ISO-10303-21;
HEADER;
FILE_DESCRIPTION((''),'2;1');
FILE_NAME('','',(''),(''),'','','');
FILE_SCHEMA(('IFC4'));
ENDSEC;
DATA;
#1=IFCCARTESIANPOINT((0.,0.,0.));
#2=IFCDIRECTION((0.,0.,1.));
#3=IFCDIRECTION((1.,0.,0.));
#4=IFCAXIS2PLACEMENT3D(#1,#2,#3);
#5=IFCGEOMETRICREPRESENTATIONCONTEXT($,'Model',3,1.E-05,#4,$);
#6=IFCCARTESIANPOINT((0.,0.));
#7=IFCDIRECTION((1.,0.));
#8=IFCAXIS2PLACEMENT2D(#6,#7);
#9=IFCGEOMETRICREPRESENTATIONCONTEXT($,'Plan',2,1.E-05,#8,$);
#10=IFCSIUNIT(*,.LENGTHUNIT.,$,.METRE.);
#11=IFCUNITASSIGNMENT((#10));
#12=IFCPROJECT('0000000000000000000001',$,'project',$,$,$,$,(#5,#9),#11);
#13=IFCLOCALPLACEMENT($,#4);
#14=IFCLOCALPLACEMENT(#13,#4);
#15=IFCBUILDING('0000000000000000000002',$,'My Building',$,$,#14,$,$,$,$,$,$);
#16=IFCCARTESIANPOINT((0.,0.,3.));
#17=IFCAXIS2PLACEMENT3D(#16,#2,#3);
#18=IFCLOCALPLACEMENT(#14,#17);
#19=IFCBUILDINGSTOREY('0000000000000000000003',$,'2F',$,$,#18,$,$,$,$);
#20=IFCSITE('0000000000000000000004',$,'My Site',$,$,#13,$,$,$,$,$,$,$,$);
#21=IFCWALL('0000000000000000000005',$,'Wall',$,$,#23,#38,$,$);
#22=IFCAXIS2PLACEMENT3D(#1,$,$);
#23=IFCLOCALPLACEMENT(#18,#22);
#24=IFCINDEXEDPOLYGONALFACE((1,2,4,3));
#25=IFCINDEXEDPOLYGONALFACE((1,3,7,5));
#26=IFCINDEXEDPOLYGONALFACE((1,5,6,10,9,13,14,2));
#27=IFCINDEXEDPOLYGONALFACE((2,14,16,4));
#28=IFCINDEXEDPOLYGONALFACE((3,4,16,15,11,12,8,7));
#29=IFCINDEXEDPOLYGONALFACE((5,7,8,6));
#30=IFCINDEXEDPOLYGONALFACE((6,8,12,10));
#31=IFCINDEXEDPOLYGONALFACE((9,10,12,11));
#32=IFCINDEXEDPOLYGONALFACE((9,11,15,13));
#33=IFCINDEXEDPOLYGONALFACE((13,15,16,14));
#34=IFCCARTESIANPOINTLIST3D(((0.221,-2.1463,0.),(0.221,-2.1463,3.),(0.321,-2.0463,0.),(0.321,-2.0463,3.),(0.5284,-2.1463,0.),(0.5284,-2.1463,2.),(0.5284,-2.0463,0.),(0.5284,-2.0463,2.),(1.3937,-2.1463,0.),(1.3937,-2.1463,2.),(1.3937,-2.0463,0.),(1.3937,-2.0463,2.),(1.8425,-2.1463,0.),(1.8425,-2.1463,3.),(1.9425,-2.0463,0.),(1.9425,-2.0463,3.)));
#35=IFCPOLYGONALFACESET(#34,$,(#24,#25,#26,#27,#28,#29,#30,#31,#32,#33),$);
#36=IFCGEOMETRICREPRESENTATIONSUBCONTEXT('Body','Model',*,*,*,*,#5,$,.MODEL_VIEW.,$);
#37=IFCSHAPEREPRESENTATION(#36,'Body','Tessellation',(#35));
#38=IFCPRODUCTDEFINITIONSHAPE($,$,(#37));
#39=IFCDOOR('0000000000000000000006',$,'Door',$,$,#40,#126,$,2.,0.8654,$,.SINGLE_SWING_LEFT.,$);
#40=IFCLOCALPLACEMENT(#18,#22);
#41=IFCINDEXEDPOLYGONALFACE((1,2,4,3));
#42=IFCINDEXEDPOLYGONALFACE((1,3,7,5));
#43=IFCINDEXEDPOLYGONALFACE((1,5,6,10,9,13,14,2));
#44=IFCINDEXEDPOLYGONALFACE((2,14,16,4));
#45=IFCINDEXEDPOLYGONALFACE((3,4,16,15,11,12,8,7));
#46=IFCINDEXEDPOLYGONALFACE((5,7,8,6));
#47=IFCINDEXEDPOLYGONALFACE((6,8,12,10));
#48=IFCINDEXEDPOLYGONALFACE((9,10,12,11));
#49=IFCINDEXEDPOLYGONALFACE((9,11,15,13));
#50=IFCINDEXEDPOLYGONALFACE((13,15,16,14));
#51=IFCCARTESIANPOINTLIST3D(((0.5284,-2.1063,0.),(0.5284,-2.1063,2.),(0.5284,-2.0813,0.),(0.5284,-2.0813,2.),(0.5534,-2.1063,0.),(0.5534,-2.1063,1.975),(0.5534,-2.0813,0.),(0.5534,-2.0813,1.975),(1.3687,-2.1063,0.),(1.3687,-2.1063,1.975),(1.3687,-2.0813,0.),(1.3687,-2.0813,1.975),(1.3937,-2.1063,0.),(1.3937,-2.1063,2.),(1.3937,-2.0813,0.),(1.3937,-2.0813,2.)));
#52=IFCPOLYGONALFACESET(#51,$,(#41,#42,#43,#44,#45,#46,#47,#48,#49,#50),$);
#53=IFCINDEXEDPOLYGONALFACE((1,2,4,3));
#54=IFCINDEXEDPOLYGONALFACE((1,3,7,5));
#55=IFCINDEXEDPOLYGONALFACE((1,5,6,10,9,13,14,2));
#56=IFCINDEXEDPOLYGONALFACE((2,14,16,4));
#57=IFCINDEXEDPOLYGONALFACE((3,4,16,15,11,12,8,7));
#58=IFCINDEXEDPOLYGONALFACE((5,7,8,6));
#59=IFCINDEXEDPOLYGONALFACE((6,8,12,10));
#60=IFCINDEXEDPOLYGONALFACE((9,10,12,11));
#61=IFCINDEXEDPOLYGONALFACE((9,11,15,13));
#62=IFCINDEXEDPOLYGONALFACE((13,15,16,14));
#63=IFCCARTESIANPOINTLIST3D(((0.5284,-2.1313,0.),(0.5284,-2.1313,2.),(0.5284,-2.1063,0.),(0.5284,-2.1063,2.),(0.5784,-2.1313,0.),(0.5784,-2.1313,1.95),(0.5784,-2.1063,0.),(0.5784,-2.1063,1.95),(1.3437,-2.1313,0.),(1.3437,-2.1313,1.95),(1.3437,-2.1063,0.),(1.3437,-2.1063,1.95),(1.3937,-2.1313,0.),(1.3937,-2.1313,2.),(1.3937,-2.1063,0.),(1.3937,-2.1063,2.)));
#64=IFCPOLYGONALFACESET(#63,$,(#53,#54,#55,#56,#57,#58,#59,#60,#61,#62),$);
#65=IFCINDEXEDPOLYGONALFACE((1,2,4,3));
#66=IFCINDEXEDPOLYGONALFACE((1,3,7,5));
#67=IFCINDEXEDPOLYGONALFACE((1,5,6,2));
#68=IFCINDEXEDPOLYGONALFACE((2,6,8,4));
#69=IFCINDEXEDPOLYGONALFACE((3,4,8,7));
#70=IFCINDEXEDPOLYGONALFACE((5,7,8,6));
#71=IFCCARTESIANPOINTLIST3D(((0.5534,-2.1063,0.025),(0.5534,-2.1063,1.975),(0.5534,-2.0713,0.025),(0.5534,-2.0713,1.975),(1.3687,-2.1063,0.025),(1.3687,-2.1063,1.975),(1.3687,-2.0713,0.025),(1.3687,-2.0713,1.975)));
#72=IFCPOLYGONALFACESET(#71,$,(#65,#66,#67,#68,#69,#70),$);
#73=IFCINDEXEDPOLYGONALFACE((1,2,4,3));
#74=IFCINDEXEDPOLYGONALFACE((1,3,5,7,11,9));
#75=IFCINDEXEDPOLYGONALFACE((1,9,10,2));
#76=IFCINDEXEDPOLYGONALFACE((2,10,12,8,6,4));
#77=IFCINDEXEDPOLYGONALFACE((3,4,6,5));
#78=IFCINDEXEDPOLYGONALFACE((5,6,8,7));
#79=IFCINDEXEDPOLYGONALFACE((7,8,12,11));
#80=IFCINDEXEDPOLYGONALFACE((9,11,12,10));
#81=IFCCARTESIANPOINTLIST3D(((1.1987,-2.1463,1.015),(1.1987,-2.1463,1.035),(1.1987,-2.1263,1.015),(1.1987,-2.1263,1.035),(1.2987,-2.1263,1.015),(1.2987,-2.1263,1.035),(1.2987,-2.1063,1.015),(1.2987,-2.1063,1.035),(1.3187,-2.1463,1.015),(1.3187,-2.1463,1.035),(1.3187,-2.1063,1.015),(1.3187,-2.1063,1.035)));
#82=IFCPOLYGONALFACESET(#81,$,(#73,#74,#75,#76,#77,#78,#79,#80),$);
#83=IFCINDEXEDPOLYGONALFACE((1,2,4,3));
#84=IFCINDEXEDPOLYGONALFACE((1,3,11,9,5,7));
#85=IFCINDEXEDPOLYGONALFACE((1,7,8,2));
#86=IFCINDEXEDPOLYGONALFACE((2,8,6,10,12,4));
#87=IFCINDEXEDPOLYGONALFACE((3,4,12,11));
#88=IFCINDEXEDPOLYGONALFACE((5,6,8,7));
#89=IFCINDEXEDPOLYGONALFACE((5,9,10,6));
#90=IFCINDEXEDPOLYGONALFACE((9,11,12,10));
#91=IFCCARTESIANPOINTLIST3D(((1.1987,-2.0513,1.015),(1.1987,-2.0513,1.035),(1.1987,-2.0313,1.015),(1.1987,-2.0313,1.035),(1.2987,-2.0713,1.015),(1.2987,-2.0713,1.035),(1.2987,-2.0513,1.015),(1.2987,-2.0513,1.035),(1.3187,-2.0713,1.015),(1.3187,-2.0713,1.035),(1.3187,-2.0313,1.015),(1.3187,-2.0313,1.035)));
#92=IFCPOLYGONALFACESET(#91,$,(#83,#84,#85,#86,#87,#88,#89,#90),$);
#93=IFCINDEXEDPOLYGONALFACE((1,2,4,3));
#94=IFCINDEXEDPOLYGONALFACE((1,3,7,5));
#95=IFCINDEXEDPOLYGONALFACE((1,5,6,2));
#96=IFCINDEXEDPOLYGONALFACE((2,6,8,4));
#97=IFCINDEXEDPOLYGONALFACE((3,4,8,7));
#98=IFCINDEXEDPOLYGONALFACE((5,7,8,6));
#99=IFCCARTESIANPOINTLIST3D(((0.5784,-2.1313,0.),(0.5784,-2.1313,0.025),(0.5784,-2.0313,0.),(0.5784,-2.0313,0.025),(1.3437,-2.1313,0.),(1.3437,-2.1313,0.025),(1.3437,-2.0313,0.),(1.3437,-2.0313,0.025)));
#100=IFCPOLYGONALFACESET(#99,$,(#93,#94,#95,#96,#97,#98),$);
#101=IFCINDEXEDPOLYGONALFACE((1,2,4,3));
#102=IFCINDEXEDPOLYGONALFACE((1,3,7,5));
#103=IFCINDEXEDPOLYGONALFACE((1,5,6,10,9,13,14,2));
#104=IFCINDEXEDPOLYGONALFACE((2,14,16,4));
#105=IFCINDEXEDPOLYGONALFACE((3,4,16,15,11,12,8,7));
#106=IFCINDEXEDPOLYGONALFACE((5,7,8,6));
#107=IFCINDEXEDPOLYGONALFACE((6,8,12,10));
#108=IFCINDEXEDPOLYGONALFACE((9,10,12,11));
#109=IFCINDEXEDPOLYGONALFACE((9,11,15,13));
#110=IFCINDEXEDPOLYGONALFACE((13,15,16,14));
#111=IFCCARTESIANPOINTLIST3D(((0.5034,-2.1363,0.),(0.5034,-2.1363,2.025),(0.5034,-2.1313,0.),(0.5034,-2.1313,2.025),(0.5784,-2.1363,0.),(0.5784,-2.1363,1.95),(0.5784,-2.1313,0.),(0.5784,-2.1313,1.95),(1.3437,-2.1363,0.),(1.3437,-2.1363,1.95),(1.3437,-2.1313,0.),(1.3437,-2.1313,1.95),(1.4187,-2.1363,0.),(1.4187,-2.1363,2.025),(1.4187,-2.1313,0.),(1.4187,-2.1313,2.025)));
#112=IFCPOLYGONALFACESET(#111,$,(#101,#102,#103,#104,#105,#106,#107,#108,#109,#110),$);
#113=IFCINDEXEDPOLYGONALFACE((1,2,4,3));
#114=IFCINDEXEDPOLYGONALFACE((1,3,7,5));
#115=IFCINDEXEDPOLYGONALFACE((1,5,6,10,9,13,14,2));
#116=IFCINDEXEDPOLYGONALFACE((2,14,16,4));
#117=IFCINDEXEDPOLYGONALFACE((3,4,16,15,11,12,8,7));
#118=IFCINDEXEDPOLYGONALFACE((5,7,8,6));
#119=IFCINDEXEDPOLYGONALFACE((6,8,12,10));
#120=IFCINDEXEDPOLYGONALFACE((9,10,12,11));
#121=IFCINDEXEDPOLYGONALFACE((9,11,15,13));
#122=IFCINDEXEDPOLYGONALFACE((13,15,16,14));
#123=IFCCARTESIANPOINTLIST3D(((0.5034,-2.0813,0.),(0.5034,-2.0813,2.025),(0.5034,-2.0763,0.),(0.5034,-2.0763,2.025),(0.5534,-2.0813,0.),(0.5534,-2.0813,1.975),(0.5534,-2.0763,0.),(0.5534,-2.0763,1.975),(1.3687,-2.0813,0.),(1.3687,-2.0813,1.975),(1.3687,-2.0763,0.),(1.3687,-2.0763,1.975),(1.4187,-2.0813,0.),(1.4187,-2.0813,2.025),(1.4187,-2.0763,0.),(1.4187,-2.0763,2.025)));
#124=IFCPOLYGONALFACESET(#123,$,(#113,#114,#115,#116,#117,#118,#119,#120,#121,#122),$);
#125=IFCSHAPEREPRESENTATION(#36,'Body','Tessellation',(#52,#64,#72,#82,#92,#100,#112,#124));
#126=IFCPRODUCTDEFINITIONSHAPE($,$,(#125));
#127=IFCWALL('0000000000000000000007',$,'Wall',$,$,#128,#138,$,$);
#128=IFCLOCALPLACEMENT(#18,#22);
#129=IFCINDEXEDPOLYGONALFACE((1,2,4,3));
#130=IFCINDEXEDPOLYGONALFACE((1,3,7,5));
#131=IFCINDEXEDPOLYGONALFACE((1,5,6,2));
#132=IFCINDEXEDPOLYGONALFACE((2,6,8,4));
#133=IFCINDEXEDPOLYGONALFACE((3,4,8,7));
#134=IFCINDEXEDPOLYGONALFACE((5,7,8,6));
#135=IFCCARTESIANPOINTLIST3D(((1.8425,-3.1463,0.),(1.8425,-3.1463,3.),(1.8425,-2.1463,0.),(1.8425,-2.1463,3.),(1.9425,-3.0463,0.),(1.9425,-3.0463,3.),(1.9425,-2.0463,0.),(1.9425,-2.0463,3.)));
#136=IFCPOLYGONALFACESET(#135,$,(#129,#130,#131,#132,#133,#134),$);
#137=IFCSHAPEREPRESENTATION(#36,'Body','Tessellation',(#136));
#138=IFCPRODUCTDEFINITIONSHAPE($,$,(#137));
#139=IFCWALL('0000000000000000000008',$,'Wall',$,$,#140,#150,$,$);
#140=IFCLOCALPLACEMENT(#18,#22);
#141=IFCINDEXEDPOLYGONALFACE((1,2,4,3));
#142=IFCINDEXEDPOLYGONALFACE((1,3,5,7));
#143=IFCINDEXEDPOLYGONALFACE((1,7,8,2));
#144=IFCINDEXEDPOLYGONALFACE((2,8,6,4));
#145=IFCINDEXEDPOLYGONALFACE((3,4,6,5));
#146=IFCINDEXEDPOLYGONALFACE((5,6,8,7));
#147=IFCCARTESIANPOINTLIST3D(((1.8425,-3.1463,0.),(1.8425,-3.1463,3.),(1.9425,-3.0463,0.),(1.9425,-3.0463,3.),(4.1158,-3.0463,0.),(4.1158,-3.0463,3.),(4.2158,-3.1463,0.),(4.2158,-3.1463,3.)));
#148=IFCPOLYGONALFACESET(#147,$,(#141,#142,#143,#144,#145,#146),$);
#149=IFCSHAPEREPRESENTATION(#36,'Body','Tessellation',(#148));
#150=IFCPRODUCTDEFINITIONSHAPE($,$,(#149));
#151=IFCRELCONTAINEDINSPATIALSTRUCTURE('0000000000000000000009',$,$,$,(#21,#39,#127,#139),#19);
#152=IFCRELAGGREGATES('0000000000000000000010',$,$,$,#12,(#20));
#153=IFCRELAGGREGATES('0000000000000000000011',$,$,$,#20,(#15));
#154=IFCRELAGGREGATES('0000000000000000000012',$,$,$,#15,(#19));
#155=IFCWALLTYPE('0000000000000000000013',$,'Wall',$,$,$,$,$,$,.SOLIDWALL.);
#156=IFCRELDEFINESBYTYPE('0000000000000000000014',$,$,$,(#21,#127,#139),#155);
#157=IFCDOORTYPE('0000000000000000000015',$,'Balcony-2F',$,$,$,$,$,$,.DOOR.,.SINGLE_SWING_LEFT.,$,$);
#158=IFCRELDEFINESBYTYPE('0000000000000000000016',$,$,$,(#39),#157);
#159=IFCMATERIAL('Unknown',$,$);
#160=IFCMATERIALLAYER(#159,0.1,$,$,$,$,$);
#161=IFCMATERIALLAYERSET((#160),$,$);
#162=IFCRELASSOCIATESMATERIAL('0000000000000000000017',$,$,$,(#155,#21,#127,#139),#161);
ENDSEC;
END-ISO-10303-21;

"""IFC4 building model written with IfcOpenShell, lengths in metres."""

from ifc_helpers import new_model, entity, si_unit, frame, origin_with_axes, origin_2d_with_axis, place, context, subcontext, project, spatial, line, indexed_curve, outline, extrude, shape, source, transform, mapped, material, layer, layer_set, layer_usage, type_object, type_shapes, element, fill, save


model = new_model("IFC4")

# Units and contexts
model_context = context("Model", 3, precision=1e-05, world=origin_with_axes())
plan_context = context("Plan", 2, precision=1e-05, world=origin_2d_with_axis())
body_context_1 = subcontext(model_context, "Body", "Model", "MODEL_VIEW")
body_context_2 = subcontext(plan_context, "Body", "Plan", "PLAN_VIEW")
ifc_project = project(units=[si_unit("LENGTHUNIT", "METRE")], contexts=[model_context, plan_context])

# Site, building, storey
site_placement = place(None, origin_with_axes())
site = spatial("IfcSite", under=ifc_project, at=site_placement, Name="My Site")
building_placement = place(site_placement, origin_with_axes())
building = spatial("IfcBuilding", under=site, at=building_placement, Name="My Building")
storey_placement = place(building_placement, frame((0.0, 0.0, 3.0), z_axis=(0.0, 0.0, 1.0), x_axis=(1.0, 0.0, 0.0)))
storey = spatial("IfcBuildingStorey", under=building, at=storey_placement, Name="2F")

# Shared definitions
ifc_material = material(Name="Unknown")

# Shared definitions
ifc_layer_1 = layer(ifc_material, 0.1)
ifc_layer_set_1 = layer_set([ifc_layer_1])
wall_type = type_object("IfcWallType", Name="Wall", PredefinedType="SOLIDWALL", material=ifc_layer_set_1)

# Wall, opening, door
ifc_layer_usage_1 = layer_usage(ifc_layer_set_1, "AXIS2", "POSITIVE", 0.0)
wall_1_placement = place(storey_placement, frame((0.221, -2.1463, 0.0), z_axis=(0.0, 0.0, 1.0), x_axis=(1.0, 0.0, 0.0)))
wall_1 = element("IfcWall", 1, at=wall_1_placement, inside=storey, type_object=wall_type, material=ifc_layer_usage_1, Name="Wall", context=body_context_1, shape_type="SweptSolid", body=[
    extrude(outline(indexed_curve([(0.0, 0.0), (0.1, 0.1), (1.7215, 0.1), (1.6215, 0.0)], segments=[line(1, 2, 3, 4, 1)])), origin_with_axes(), (0.0, 0.0, 1.0), 3.0),
])
shared_shape_1 = source(origin_with_axes(), body_context_1, "Body", "SweptSolid", [
    extrude(outline(indexed_curve([(0.0, 0.0), (0.8654, 0.0), (0.8654, 2.0), (0.0, 2.0)], segments=[line(1, 2, 3, 4, 1)])), frame((0.0, -0.6, 0.0), z_axis=(0.0, -1.0, 0.0), x_axis=(1.0, 0.0, 0.0)), (0.0, 0.0, -1.0), 1.2),
])
opening_1_placement = place(wall_1_placement, frame((0.3074, 0.015, 0.0), z_axis=(0.0, 0.0, 1.0), x_axis=(1.0, 0.0, 0.0)))
opening_1 = element("IfcOpeningElement", 2, at=opening_1_placement, cuts=wall_1, PredefinedType="OPENING", context=body_context_1, shape_type="MappedRepresentation", body=[
    mapped(shared_shape_1, transform((0.0, 0.0, 0.0), x_axis=(1.0, 0.0, 0.0), y_axis=(0.0, 1.0, 0.0), z_axis=(0.0, 0.0, 1.0), scale=1.0)),
])
door_type_1 = type_object("IfcDoorType", Name="Balcony-2F", OperationType="SINGLE_SWING_LEFT", PredefinedType="DOOR")
shared_shape_2 = source(origin_with_axes(), body_context_1, "Body", "SweptSolid", [
    extrude(outline(indexed_curve([(0.0, 0.0), (0.0, 2.0), (0.8654, 2.0), (0.8654, 0.0), (0.8404, 0.0), (0.8404, 1.975), (0.025, 1.975), (0.025, 0.0)], segments=[line(1, 2, 3, 4, 5, 6, 7, 8, 1)])), frame((0.0, 0.025, 0.0), z_axis=(0.0, -1.0, 0.0), x_axis=(1.0, 0.0, 0.0)), (0.0, 0.0, -1.0), 0.025),
    extrude(outline(indexed_curve([(0.0, 0.0), (0.0, 2.0), (0.8654, 2.0), (0.8654, 0.0), (0.8154, 0.0), (0.8154, 1.95), (0.05, 1.95), (0.05, 0.0)], segments=[line(1, 2, 3, 4, 5, 6, 7, 8, 1)])), frame((0.0, 0.0, 0.0), z_axis=(0.0, -1.0, 0.0), x_axis=(1.0, 0.0, 0.0)), (0.0, 0.0, -1.0), 0.025),
    extrude(outline(indexed_curve([(0.0, 0.0), (0.8154, 0.0), (0.8154, 0.035), (0.0, 0.035)], segments=[line(1, 2, 3, 4, 1)])), frame((0.025, 0.025, 0.025), z_axis=(0.0, 0.0, 1.0), x_axis=(1.0, 0.0, 0.0)), (0.0, 0.0, 1.0), 1.95),
    extrude(outline(indexed_curve([(0.0, 0.0), (0.0, -0.04), (-0.12, -0.04), (-0.12, -0.02), (-0.02, -0.02), (-0.02, 0.0)], segments=[line(1, 2, 3, 4, 5, 6, 1)])), frame((0.7904, 0.025, 1.015), z_axis=(0.0, 0.0, 1.0), x_axis=(1.0, 0.0, 0.0)), (0.0, 0.0, 1.0), 0.02),
    extrude(outline(indexed_curve([(0.0, 0.0), (0.0, 0.04), (-0.12, 0.04), (-0.12, 0.02), (-0.02, 0.02), (-0.02, 0.0)], segments=[line(1, 2, 3, 4, 5, 6, 1)])), frame((0.7904, 0.06, 1.015), z_axis=(0.0, 0.0, 1.0), x_axis=(1.0, 0.0, 0.0)), (0.0, 0.0, 1.0), 0.02),
    extrude(outline(indexed_curve([(0.0, 0.0), (0.7654, 0.0), (0.7654, 0.1), (0.0, 0.1)], segments=[line(1, 2, 3, 4, 1)])), frame((0.05, 0.0, 0.0), z_axis=(0.0, 0.0, 1.0), x_axis=(1.0, 0.0, 0.0)), (0.0, 0.0, 1.0), 0.025),
    extrude(outline(indexed_curve([(0.0, 0.0), (0.0, 2.025), (0.9154, 2.025), (0.9154, 0.0), (0.8404, 0.0), (0.8404, 1.95), (0.075, 1.95), (0.075, 0.0)], segments=[line(1, 2, 3, 4, 5, 6, 7, 8, 1)])), frame((-0.025, -0.005, 0.0), z_axis=(0.0, -1.0, 0.0), x_axis=(1.0, 0.0, 0.0)), (0.0, 0.0, -1.0), 0.005),
    extrude(outline(indexed_curve([(0.0, 0.0), (0.0, 2.025), (0.9154, 2.025), (0.9154, 0.0), (0.8654, 0.0), (0.8654, 1.975), (0.05, 1.975), (0.05, 0.0)], segments=[line(1, 2, 3, 4, 5, 6, 7, 8, 1)])), frame((-0.025, 0.05, 0.0), z_axis=(0.0, -1.0, 0.0), x_axis=(1.0, 0.0, 0.0)), (0.0, 0.0, -1.0), 0.005),
])
shared_shape_3 = source(origin_with_axes(), body_context_2, "Body", "Curve2D", [
    entity("IfcIndexedPolyCurve", entity("IfcCartesianPointList2D", [[0.0, 0.0], [0.0, 0.05], [0.025, 0.05], [0.025, 0.025], [0.05, 0.025], [0.05, 0.0]]), [entity("IfcLineIndex", [1, 2, 3, 4, 5, 6, 1])]),
    entity("IfcIndexedPolyCurve", entity("IfcCartesianPointList2D", [[0.8654, 0.0], [0.8654, 0.05], [0.8404, 0.05], [0.8404, 0.025], [0.8154, 0.025], [0.8154, 0.0]]), [entity("IfcLineIndex", [1, 2, 3, 4, 5, 6, 1])]),
    entity("IfcTrimmedCurve", entity("IfcEllipse", entity("IfcAxis2Placement2D", entity("IfcCartesianPoint", [0.06, 0.05]), entity("IfcDirection", [1.0, 0.0])), 0.7804, 0.8154), [entity("IfcCartesianPoint", [0.8404, 0.05])], [entity("IfcCartesianPoint", [0.06, 0.8654])], True, "CARTESIAN"),
    entity("IfcIndexedPolyCurve", entity("IfcCartesianPointList2D", [[0.025, 0.05], [0.06, 0.05], [0.06, 0.8654], [0.025, 0.8654]]), [entity("IfcLineIndex", [1, 2, 3, 4, 1])]),
])
type_shapes(door_type_1, [shared_shape_2, shared_shape_3])
door_1_placement = place(opening_1_placement, frame((0.0, 0.0, 0.0), z_axis=(0.0, 0.0, 1.0), x_axis=(1.0, 0.0, 0.0)))
door_1 = element("IfcDoor", 3, at=door_1_placement, inside=storey, type_object=door_type_1, Name="Door", OperationType="SINGLE_SWING_LEFT", OverallHeight=2.0, OverallWidth=0.8654, shapes=[
    shape(body_context_1, "Body", "MappedRepresentation", [mapped(shared_shape_2, transform((0.0, 0.0, 0.0), x_axis=(1.0, 0.0, 0.0), y_axis=(0.0, 1.0, 0.0), z_axis=(0.0, 0.0, 1.0), scale=1.0))]),
    shape(body_context_2, "Body", "MappedRepresentation", [mapped(shared_shape_3, transform((0.0, 0.0, 0.0), x_axis=(1.0, 0.0, 0.0), y_axis=(0.0, 1.0, 0.0), z_axis=(0.0, 0.0, 1.0), scale=1.0))]),
])
fill(opening_1, door_1)

# Walls
ifc_layer_usage_2 = layer_usage(ifc_layer_set_1, "AXIS2", "POSITIVE", 0.0)
wall_2_placement = place(storey_placement, frame((1.8425, -2.1463, 0.0), z_axis=(0.0, 0.0, 1.0), x_axis=(0.0, -1.0, 0.0)))
element("IfcWall", 4, at=wall_2_placement, inside=storey, type_object=wall_type, material=ifc_layer_usage_2, Name="Wall", context=body_context_1, shape_type="SweptSolid", body=[
    extrude(outline(indexed_curve([(0.0, 0.0), (-0.1, 0.1), (0.9, 0.1), (1.0, 0.0)], segments=[line(1, 2, 3, 4, 1)])), origin_with_axes(), (0.0, 0.0, 1.0), 3.0),
])
ifc_layer_usage_3 = layer_usage(ifc_layer_set_1, "AXIS2", "POSITIVE", 0.0)
wall_3_placement = place(storey_placement, frame((1.8425, -3.1463, 0.0), z_axis=(0.0, 0.0, 1.0), x_axis=(1.0, 0.0, 0.0)))
element("IfcWall", 5, at=wall_3_placement, inside=storey, type_object=wall_type, material=ifc_layer_usage_3, Name="Wall", context=body_context_1, shape_type="SweptSolid", body=[
    extrude(outline(indexed_curve([(0.0, 0.0), (0.1, 0.1), (2.2734, 0.1), (2.3734, 0.0)], segments=[line(1, 2, 3, 4, 1)])), origin_with_axes(), (0.0, 0.0, 1.0), 3.0),
])

save(model, "model.ifc")
